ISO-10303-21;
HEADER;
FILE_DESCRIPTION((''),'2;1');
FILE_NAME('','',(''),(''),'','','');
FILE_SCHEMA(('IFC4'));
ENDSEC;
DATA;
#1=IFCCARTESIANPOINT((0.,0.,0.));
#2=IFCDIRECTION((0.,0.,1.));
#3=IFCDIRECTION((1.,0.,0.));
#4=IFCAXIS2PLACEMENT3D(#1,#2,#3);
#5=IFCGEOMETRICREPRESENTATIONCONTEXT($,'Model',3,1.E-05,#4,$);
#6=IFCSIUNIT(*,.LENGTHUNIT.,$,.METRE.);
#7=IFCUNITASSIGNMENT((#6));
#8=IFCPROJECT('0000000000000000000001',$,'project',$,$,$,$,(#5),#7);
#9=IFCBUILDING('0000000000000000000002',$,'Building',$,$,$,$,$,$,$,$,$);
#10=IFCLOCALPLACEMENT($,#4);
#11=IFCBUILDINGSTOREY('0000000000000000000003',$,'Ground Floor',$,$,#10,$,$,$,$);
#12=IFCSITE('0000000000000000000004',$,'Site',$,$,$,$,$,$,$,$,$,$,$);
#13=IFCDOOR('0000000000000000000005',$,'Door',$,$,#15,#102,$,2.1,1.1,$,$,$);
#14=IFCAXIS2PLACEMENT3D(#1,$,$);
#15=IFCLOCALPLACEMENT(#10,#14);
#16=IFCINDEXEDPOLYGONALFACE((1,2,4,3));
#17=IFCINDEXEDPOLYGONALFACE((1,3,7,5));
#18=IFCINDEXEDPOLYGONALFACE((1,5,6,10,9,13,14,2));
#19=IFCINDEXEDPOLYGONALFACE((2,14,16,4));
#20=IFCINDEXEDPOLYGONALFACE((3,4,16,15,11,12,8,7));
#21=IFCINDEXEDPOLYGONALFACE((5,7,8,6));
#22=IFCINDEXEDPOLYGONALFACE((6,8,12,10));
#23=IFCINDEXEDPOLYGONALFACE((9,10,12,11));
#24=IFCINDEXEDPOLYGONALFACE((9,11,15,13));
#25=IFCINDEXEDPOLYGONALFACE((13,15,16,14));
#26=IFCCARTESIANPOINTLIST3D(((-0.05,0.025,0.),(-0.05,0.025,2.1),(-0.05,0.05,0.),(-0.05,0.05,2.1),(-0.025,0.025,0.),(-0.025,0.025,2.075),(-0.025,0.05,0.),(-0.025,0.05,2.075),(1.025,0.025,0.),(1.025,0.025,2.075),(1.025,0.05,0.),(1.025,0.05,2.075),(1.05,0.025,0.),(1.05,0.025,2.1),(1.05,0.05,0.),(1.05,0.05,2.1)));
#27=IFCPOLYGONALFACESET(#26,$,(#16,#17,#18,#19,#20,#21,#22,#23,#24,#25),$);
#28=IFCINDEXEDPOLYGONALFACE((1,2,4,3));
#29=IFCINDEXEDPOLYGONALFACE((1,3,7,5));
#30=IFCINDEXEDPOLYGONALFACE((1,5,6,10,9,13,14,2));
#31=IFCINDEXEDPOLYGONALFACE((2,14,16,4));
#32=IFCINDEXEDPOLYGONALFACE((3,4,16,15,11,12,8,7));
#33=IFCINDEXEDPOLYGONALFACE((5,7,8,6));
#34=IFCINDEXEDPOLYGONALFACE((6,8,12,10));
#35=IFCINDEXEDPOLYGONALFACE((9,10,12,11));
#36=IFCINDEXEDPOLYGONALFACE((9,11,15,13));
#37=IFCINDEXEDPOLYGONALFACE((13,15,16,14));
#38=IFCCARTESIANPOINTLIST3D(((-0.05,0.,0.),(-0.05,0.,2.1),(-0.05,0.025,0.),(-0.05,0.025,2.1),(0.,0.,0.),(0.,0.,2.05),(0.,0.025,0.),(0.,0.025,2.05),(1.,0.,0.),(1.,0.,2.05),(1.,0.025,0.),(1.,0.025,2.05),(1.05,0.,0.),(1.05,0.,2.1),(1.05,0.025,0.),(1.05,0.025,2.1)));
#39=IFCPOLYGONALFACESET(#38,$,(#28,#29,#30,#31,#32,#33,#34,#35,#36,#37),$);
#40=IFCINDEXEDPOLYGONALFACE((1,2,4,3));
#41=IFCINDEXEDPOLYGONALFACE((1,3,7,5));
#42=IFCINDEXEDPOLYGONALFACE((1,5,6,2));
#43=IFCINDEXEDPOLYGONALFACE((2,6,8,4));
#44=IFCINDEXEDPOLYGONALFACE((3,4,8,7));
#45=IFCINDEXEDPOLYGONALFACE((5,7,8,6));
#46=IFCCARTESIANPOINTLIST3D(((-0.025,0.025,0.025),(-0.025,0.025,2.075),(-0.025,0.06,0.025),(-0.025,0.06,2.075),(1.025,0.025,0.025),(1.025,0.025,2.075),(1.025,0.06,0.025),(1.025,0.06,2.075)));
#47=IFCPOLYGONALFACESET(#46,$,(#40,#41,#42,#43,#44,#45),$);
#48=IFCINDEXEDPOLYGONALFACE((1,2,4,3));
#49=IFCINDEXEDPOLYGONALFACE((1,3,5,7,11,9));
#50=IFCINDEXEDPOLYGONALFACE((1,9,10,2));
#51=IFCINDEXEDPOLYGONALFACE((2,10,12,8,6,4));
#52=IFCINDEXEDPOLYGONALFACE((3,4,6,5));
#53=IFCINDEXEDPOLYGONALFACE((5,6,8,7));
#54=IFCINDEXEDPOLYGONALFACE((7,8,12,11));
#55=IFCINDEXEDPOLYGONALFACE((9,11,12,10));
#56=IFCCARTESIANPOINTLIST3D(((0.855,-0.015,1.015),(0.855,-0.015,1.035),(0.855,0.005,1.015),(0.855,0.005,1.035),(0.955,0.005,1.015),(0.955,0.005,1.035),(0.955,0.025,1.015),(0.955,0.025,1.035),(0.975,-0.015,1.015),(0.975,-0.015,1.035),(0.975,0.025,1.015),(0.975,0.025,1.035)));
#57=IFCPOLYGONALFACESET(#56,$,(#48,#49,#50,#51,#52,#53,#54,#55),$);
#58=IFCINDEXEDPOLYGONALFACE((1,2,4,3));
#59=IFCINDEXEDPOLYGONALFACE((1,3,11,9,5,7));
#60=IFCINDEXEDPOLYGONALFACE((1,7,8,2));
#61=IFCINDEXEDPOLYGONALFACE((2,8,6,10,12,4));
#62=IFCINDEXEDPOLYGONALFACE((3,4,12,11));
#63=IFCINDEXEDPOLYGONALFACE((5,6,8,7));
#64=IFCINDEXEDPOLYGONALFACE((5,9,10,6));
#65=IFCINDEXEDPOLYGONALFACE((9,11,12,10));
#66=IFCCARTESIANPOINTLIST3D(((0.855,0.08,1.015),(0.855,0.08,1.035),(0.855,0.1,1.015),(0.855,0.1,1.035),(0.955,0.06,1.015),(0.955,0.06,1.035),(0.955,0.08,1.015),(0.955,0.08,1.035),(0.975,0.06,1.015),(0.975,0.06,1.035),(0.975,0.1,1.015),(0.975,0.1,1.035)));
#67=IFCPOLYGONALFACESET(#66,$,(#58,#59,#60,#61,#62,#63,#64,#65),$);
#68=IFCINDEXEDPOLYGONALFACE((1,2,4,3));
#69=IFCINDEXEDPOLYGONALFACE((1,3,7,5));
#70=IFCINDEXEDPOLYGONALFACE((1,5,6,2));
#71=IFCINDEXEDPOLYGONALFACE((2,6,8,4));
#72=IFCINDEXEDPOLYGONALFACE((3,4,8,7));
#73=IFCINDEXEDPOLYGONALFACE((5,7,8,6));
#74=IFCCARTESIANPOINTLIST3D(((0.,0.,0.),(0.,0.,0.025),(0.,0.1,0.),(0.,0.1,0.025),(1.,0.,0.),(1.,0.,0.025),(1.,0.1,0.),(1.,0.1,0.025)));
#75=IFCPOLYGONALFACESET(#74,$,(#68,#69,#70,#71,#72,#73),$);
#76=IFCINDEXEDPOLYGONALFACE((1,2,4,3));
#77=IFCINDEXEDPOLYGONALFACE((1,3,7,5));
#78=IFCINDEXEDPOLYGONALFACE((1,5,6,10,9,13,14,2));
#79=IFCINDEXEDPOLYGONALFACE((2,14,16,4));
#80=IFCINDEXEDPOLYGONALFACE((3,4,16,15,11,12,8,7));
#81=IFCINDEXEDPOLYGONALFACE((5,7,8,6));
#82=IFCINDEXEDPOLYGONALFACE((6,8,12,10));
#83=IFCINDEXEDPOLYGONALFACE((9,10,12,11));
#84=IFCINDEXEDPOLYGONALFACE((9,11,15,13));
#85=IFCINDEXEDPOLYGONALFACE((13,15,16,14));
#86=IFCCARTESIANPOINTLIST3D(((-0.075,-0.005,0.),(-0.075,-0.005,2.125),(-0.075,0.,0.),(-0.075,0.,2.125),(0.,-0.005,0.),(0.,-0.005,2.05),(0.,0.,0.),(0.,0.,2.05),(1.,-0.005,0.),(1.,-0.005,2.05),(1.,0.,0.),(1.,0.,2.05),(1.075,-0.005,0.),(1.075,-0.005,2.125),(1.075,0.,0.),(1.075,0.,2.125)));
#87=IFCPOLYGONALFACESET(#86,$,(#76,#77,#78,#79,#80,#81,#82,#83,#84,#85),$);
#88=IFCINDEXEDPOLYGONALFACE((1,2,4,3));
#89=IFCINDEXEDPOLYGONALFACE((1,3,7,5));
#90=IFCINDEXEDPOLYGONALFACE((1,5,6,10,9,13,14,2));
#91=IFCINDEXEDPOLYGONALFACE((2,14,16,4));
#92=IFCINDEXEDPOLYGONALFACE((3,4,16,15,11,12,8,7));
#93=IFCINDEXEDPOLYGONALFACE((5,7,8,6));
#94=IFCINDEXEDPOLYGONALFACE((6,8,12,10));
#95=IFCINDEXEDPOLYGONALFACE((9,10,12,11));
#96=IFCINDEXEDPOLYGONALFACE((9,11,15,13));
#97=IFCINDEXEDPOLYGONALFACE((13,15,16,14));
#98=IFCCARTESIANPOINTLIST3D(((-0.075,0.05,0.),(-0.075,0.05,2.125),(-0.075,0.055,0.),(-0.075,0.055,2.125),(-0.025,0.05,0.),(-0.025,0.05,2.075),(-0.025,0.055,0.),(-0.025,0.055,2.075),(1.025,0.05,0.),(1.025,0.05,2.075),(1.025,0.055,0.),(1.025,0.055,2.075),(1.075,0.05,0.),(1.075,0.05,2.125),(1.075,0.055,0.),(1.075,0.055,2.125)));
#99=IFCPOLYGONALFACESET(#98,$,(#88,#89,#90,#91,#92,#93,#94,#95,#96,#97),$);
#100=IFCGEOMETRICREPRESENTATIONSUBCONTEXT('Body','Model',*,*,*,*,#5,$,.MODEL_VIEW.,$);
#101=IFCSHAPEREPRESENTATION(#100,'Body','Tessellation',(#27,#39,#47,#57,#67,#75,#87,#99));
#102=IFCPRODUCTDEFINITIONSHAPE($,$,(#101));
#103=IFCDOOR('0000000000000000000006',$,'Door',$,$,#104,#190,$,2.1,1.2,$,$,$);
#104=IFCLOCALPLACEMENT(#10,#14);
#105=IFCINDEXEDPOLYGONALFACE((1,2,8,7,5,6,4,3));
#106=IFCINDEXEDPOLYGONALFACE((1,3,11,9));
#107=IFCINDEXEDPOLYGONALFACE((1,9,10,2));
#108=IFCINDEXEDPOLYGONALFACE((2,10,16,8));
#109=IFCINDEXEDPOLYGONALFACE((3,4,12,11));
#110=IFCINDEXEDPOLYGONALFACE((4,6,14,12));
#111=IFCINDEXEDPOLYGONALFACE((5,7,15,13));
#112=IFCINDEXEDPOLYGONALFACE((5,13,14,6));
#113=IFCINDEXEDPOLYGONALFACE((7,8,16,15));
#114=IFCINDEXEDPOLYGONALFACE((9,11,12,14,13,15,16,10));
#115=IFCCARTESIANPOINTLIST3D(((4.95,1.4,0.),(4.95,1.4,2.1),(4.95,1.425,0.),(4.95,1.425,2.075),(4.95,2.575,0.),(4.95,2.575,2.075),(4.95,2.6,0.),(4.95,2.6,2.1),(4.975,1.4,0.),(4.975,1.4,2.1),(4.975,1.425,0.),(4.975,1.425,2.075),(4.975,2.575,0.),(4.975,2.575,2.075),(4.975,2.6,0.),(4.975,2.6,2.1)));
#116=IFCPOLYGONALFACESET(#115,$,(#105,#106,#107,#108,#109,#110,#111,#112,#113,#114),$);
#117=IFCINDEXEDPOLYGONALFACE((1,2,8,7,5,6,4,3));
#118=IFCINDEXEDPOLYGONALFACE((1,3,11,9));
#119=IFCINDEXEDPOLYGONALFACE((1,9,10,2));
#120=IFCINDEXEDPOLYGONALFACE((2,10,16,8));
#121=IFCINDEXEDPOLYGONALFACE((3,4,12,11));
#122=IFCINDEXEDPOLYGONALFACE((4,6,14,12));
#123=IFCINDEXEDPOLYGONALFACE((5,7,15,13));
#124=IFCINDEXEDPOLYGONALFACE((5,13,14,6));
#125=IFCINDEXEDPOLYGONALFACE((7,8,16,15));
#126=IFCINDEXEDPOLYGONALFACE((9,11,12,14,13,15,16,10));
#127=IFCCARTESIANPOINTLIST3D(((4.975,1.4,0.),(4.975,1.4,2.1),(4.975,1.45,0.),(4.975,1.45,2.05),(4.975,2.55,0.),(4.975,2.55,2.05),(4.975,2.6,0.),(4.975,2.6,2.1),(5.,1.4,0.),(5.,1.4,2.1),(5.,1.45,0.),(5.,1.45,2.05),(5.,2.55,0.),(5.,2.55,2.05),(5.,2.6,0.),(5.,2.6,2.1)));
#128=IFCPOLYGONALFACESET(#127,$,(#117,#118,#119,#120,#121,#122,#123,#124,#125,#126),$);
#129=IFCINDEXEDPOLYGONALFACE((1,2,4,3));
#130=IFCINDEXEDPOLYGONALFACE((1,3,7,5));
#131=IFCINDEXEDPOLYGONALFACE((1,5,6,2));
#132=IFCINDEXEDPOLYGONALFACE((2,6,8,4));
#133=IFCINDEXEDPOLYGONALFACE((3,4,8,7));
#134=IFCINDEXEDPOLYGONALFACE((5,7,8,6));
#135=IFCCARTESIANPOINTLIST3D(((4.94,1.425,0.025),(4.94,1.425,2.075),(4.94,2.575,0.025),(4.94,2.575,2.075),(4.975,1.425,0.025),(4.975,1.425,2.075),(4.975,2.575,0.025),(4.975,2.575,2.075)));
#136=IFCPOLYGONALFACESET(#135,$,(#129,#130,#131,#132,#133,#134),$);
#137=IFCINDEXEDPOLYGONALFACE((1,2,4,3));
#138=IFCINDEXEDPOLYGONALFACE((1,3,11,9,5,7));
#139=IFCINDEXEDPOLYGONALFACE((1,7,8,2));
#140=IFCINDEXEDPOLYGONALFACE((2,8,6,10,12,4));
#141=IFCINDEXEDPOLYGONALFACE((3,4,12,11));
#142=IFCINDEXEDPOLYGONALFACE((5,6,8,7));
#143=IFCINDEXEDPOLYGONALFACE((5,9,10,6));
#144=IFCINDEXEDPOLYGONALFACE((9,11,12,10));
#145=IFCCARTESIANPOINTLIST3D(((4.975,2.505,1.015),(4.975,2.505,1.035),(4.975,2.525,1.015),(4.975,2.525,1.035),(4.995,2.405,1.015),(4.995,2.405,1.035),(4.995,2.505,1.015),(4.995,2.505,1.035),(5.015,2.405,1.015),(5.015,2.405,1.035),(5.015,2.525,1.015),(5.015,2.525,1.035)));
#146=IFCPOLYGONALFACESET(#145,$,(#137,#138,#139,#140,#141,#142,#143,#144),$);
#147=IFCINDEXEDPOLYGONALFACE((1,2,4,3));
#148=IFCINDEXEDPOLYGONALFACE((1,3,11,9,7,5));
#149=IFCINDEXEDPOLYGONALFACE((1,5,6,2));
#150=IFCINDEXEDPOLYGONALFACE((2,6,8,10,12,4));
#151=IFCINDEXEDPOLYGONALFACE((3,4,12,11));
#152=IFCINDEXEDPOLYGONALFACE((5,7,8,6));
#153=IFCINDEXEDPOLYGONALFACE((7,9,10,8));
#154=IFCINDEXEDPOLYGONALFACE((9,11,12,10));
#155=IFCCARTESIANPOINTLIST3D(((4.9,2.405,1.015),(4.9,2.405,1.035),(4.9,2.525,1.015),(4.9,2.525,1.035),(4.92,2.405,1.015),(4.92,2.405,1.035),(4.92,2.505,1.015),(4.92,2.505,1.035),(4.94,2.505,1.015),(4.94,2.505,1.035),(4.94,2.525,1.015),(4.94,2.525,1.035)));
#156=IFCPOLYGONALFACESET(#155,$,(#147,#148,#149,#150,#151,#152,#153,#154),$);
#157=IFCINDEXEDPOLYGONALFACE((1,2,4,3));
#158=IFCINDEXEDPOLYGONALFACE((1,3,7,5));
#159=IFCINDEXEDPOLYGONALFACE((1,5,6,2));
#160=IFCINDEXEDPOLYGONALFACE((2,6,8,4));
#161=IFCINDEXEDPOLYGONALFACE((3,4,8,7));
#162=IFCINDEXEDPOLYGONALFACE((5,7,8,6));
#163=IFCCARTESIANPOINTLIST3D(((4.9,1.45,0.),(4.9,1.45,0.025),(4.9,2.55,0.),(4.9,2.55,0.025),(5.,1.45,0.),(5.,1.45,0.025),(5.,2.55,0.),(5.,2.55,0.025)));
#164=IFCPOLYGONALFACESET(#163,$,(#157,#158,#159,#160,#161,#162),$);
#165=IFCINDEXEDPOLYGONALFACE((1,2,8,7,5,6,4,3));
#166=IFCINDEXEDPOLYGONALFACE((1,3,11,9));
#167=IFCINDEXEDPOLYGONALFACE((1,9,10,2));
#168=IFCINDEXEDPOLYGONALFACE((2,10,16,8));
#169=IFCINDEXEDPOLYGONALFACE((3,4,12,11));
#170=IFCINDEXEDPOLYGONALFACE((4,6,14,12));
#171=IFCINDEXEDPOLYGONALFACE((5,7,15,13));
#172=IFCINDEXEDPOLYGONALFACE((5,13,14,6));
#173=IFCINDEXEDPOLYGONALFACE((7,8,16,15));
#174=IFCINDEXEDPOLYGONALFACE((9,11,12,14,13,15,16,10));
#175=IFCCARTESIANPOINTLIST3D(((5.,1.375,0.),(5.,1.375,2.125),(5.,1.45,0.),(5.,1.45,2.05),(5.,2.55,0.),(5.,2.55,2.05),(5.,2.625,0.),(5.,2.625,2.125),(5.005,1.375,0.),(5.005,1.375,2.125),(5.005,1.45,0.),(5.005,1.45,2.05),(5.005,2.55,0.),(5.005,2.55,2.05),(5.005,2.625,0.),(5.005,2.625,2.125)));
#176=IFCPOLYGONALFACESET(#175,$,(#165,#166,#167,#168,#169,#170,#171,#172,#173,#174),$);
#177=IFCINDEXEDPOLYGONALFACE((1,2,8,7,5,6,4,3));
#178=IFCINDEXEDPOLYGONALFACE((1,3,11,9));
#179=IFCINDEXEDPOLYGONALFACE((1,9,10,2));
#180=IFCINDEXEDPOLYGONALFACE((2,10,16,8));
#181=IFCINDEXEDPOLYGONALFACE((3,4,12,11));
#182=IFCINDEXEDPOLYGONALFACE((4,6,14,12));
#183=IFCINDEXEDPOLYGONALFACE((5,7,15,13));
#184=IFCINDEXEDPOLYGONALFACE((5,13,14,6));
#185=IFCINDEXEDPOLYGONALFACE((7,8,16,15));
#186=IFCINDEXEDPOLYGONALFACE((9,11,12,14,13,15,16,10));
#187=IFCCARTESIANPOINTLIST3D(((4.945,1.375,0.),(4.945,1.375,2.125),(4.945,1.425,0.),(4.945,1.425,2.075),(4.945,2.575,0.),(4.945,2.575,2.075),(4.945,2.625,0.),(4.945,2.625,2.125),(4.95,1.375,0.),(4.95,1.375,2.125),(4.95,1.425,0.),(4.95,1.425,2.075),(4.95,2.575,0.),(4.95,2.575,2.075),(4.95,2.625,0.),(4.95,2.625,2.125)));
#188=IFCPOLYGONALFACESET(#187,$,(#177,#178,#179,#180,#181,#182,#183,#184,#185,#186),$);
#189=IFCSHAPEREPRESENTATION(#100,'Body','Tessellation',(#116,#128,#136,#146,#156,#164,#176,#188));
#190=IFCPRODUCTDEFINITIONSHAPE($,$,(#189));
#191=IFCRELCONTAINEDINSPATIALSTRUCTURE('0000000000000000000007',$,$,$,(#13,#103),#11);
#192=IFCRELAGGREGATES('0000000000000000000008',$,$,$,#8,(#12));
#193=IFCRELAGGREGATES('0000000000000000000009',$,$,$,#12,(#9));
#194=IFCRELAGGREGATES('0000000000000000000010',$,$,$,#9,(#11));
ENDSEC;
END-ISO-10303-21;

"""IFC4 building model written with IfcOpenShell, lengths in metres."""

from ifc_helpers import new_model, si_unit, frame, origin_with_axes, place, context, subcontext, project, spatial, line, indexed_curve, outline, extrude, element, save


model = new_model("IFC4")

# Units and contexts
model_context = context("Model", 3, precision=1e-05, world=origin_with_axes())
body_context = subcontext(model_context, "Body", "Model", "MODEL_VIEW")
ifc_project = project(units=[si_unit("LENGTHUNIT", "METRE")], contexts=[model_context])

# Site, building, storey
site = spatial("IfcSite", under=ifc_project, Name="Site")
building = spatial("IfcBuilding", under=site, Name="Building")
storey_placement = place(None, origin_with_axes())
storey = spatial("IfcBuildingStorey", under=building, at=storey_placement, Name="Ground Floor")

# Doors
door_1_placement = place(storey_placement, frame((-0.05, 0.0, 0.0), z_axis=(0.0, 0.0, 1.0), x_axis=(1.0, 0.0, 0.0)))
element("IfcDoor", 1, at=door_1_placement, inside=storey, Name="Door", OverallHeight=2.1, OverallWidth=1.1, context=body_context, shape_type="SweptSolid", body=[
    extrude(outline(indexed_curve([(0.0, 0.0), (0.0, 2.1), (1.1, 2.1), (1.1, 0.0), (1.075, 0.0), (1.075, 2.075), (0.025, 2.075), (0.025, 0.0)], segments=[line(1, 2, 3, 4, 5, 6, 7, 8, 1)])), frame((0.0, 0.025, 0.0), z_axis=(0.0, -1.0, 0.0), x_axis=(1.0, 0.0, 0.0)), (0.0, 0.0, -1.0), 0.025),
    extrude(outline(indexed_curve([(0.0, 0.0), (0.0, 2.1), (1.1, 2.1), (1.1, 0.0), (1.05, 0.0), (1.05, 2.05), (0.05, 2.05), (0.05, 0.0)], segments=[line(1, 2, 3, 4, 5, 6, 7, 8, 1)])), frame((0.0, 0.0, 0.0), z_axis=(0.0, -1.0, 0.0), x_axis=(1.0, 0.0, 0.0)), (0.0, 0.0, -1.0), 0.025),
    extrude(outline(indexed_curve([(0.0, 0.0), (1.05, 0.0), (1.05, 0.035), (0.0, 0.035)], segments=[line(1, 2, 3, 4, 1)])), frame((0.025, 0.025, 0.025), z_axis=(0.0, 0.0, 1.0), x_axis=(1.0, 0.0, 0.0)), (0.0, 0.0, 1.0), 2.05),
    extrude(outline(indexed_curve([(0.0, 0.0), (0.0, -0.04), (-0.12, -0.04), (-0.12, -0.02), (-0.02, -0.02), (-0.02, 0.0)], segments=[line(1, 2, 3, 4, 5, 6, 1)])), frame((1.025, 0.025, 1.015), z_axis=(0.0, 0.0, 1.0), x_axis=(1.0, 0.0, 0.0)), (0.0, 0.0, 1.0), 0.02),
    extrude(outline(indexed_curve([(0.0, 0.0), (0.0, 0.04), (-0.12, 0.04), (-0.12, 0.02), (-0.02, 0.02), (-0.02, 0.0)], segments=[line(1, 2, 3, 4, 5, 6, 1)])), frame((1.025, 0.06, 1.015), z_axis=(0.0, 0.0, 1.0), x_axis=(1.0, 0.0, 0.0)), (0.0, 0.0, 1.0), 0.02),
    extrude(outline(indexed_curve([(0.0, 0.0), (1.0, 0.0), (1.0, 0.1), (0.0, 0.1)], segments=[line(1, 2, 3, 4, 1)])), frame((0.05, 0.0, 0.0), z_axis=(0.0, 0.0, 1.0), x_axis=(1.0, 0.0, 0.0)), (0.0, 0.0, 1.0), 0.025),
    extrude(outline(indexed_curve([(0.0, 0.0), (0.0, 2.125), (1.15, 2.125), (1.15, 0.0), (1.075, 0.0), (1.075, 2.05), (0.075, 2.05), (0.075, 0.0)], segments=[line(1, 2, 3, 4, 5, 6, 7, 8, 1)])), frame((-0.025, -0.005, 0.0), z_axis=(0.0, -1.0, 0.0), x_axis=(1.0, 0.0, 0.0)), (0.0, 0.0, -1.0), 0.005),
    extrude(outline(indexed_curve([(0.0, 0.0), (0.0, 2.125), (1.15, 2.125), (1.15, 0.0), (1.1, 0.0), (1.1, 2.075), (0.05, 2.075), (0.05, 0.0)], segments=[line(1, 2, 3, 4, 5, 6, 7, 8, 1)])), frame((-0.025, 0.05, 0.0), z_axis=(0.0, -1.0, 0.0), x_axis=(1.0, 0.0, 0.0)), (0.0, 0.0, -1.0), 0.005),
])
door_2_placement = place(storey_placement, frame((5.0, 1.4, 0.0), z_axis=(0.0, 0.0, 1.0), x_axis=(0.0, 1.0, 0.0)))
element("IfcDoor", 2, at=door_2_placement, inside=storey, Name="Door", OverallHeight=2.1, OverallWidth=1.2, context=body_context, shape_type="SweptSolid", body=[
    extrude(outline(indexed_curve([(0.0, 0.0), (0.0, 2.1), (1.2, 2.1), (1.2, 0.0), (1.175, 0.0), (1.175, 2.075), (0.025, 2.075), (0.025, 0.0)], segments=[line(1, 2, 3, 4, 5, 6, 7, 8, 1)])), frame((0.0, 0.025, 0.0), z_axis=(0.0, -1.0, 0.0), x_axis=(1.0, 0.0, 0.0)), (0.0, 0.0, -1.0), 0.025),
    extrude(outline(indexed_curve([(0.0, 0.0), (0.0, 2.1), (1.2, 2.1), (1.2, 0.0), (1.15, 0.0), (1.15, 2.05), (0.05, 2.05), (0.05, 0.0)], segments=[line(1, 2, 3, 4, 5, 6, 7, 8, 1)])), frame((0.0, 0.0, 0.0), z_axis=(0.0, -1.0, 0.0), x_axis=(1.0, 0.0, 0.0)), (0.0, 0.0, -1.0), 0.025),
    extrude(outline(indexed_curve([(0.0, 0.0), (1.15, 0.0), (1.15, 0.035), (0.0, 0.035)], segments=[line(1, 2, 3, 4, 1)])), frame((0.025, 0.025, 0.025), z_axis=(0.0, 0.0, 1.0), x_axis=(1.0, 0.0, 0.0)), (0.0, 0.0, 1.0), 2.05),
    extrude(outline(indexed_curve([(0.0, 0.0), (0.0, -0.04), (-0.12, -0.04), (-0.12, -0.02), (-0.02, -0.02), (-0.02, 0.0)], segments=[line(1, 2, 3, 4, 5, 6, 1)])), frame((1.125, 0.025, 1.015), z_axis=(0.0, 0.0, 1.0), x_axis=(1.0, 0.0, 0.0)), (0.0, 0.0, 1.0), 0.02),
    extrude(outline(indexed_curve([(0.0, 0.0), (0.0, 0.04), (-0.12, 0.04), (-0.12, 0.02), (-0.02, 0.02), (-0.02, 0.0)], segments=[line(1, 2, 3, 4, 5, 6, 1)])), frame((1.125, 0.06, 1.015), z_axis=(0.0, 0.0, 1.0), x_axis=(1.0, 0.0, 0.0)), (0.0, 0.0, 1.0), 0.02),
    extrude(outline(indexed_curve([(0.0, 0.0), (1.1, 0.0), (1.1, 0.1), (0.0, 0.1)], segments=[line(1, 2, 3, 4, 1)])), frame((0.05, 0.0, 0.0), z_axis=(0.0, 0.0, 1.0), x_axis=(1.0, 0.0, 0.0)), (0.0, 0.0, 1.0), 0.025),
    extrude(outline(indexed_curve([(0.0, 0.0), (0.0, 2.125), (1.25, 2.125), (1.25, 0.0), (1.175, 0.0), (1.175, 2.05), (0.075, 2.05), (0.075, 0.0)], segments=[line(1, 2, 3, 4, 5, 6, 7, 8, 1)])), frame((-0.025, -0.005, 0.0), z_axis=(0.0, -1.0, 0.0), x_axis=(1.0, 0.0, 0.0)), (0.0, 0.0, -1.0), 0.005),
    extrude(outline(indexed_curve([(0.0, 0.0), (0.0, 2.125), (1.25, 2.125), (1.25, 0.0), (1.2, 0.0), (1.2, 2.075), (0.05, 2.075), (0.05, 0.0)], segments=[line(1, 2, 3, 4, 5, 6, 7, 8, 1)])), frame((-0.025, 0.05, 0.0), z_axis=(0.0, -1.0, 0.0), x_axis=(1.0, 0.0, 0.0)), (0.0, 0.0, -1.0), 0.005),
])

save(model, "model.ifc")
